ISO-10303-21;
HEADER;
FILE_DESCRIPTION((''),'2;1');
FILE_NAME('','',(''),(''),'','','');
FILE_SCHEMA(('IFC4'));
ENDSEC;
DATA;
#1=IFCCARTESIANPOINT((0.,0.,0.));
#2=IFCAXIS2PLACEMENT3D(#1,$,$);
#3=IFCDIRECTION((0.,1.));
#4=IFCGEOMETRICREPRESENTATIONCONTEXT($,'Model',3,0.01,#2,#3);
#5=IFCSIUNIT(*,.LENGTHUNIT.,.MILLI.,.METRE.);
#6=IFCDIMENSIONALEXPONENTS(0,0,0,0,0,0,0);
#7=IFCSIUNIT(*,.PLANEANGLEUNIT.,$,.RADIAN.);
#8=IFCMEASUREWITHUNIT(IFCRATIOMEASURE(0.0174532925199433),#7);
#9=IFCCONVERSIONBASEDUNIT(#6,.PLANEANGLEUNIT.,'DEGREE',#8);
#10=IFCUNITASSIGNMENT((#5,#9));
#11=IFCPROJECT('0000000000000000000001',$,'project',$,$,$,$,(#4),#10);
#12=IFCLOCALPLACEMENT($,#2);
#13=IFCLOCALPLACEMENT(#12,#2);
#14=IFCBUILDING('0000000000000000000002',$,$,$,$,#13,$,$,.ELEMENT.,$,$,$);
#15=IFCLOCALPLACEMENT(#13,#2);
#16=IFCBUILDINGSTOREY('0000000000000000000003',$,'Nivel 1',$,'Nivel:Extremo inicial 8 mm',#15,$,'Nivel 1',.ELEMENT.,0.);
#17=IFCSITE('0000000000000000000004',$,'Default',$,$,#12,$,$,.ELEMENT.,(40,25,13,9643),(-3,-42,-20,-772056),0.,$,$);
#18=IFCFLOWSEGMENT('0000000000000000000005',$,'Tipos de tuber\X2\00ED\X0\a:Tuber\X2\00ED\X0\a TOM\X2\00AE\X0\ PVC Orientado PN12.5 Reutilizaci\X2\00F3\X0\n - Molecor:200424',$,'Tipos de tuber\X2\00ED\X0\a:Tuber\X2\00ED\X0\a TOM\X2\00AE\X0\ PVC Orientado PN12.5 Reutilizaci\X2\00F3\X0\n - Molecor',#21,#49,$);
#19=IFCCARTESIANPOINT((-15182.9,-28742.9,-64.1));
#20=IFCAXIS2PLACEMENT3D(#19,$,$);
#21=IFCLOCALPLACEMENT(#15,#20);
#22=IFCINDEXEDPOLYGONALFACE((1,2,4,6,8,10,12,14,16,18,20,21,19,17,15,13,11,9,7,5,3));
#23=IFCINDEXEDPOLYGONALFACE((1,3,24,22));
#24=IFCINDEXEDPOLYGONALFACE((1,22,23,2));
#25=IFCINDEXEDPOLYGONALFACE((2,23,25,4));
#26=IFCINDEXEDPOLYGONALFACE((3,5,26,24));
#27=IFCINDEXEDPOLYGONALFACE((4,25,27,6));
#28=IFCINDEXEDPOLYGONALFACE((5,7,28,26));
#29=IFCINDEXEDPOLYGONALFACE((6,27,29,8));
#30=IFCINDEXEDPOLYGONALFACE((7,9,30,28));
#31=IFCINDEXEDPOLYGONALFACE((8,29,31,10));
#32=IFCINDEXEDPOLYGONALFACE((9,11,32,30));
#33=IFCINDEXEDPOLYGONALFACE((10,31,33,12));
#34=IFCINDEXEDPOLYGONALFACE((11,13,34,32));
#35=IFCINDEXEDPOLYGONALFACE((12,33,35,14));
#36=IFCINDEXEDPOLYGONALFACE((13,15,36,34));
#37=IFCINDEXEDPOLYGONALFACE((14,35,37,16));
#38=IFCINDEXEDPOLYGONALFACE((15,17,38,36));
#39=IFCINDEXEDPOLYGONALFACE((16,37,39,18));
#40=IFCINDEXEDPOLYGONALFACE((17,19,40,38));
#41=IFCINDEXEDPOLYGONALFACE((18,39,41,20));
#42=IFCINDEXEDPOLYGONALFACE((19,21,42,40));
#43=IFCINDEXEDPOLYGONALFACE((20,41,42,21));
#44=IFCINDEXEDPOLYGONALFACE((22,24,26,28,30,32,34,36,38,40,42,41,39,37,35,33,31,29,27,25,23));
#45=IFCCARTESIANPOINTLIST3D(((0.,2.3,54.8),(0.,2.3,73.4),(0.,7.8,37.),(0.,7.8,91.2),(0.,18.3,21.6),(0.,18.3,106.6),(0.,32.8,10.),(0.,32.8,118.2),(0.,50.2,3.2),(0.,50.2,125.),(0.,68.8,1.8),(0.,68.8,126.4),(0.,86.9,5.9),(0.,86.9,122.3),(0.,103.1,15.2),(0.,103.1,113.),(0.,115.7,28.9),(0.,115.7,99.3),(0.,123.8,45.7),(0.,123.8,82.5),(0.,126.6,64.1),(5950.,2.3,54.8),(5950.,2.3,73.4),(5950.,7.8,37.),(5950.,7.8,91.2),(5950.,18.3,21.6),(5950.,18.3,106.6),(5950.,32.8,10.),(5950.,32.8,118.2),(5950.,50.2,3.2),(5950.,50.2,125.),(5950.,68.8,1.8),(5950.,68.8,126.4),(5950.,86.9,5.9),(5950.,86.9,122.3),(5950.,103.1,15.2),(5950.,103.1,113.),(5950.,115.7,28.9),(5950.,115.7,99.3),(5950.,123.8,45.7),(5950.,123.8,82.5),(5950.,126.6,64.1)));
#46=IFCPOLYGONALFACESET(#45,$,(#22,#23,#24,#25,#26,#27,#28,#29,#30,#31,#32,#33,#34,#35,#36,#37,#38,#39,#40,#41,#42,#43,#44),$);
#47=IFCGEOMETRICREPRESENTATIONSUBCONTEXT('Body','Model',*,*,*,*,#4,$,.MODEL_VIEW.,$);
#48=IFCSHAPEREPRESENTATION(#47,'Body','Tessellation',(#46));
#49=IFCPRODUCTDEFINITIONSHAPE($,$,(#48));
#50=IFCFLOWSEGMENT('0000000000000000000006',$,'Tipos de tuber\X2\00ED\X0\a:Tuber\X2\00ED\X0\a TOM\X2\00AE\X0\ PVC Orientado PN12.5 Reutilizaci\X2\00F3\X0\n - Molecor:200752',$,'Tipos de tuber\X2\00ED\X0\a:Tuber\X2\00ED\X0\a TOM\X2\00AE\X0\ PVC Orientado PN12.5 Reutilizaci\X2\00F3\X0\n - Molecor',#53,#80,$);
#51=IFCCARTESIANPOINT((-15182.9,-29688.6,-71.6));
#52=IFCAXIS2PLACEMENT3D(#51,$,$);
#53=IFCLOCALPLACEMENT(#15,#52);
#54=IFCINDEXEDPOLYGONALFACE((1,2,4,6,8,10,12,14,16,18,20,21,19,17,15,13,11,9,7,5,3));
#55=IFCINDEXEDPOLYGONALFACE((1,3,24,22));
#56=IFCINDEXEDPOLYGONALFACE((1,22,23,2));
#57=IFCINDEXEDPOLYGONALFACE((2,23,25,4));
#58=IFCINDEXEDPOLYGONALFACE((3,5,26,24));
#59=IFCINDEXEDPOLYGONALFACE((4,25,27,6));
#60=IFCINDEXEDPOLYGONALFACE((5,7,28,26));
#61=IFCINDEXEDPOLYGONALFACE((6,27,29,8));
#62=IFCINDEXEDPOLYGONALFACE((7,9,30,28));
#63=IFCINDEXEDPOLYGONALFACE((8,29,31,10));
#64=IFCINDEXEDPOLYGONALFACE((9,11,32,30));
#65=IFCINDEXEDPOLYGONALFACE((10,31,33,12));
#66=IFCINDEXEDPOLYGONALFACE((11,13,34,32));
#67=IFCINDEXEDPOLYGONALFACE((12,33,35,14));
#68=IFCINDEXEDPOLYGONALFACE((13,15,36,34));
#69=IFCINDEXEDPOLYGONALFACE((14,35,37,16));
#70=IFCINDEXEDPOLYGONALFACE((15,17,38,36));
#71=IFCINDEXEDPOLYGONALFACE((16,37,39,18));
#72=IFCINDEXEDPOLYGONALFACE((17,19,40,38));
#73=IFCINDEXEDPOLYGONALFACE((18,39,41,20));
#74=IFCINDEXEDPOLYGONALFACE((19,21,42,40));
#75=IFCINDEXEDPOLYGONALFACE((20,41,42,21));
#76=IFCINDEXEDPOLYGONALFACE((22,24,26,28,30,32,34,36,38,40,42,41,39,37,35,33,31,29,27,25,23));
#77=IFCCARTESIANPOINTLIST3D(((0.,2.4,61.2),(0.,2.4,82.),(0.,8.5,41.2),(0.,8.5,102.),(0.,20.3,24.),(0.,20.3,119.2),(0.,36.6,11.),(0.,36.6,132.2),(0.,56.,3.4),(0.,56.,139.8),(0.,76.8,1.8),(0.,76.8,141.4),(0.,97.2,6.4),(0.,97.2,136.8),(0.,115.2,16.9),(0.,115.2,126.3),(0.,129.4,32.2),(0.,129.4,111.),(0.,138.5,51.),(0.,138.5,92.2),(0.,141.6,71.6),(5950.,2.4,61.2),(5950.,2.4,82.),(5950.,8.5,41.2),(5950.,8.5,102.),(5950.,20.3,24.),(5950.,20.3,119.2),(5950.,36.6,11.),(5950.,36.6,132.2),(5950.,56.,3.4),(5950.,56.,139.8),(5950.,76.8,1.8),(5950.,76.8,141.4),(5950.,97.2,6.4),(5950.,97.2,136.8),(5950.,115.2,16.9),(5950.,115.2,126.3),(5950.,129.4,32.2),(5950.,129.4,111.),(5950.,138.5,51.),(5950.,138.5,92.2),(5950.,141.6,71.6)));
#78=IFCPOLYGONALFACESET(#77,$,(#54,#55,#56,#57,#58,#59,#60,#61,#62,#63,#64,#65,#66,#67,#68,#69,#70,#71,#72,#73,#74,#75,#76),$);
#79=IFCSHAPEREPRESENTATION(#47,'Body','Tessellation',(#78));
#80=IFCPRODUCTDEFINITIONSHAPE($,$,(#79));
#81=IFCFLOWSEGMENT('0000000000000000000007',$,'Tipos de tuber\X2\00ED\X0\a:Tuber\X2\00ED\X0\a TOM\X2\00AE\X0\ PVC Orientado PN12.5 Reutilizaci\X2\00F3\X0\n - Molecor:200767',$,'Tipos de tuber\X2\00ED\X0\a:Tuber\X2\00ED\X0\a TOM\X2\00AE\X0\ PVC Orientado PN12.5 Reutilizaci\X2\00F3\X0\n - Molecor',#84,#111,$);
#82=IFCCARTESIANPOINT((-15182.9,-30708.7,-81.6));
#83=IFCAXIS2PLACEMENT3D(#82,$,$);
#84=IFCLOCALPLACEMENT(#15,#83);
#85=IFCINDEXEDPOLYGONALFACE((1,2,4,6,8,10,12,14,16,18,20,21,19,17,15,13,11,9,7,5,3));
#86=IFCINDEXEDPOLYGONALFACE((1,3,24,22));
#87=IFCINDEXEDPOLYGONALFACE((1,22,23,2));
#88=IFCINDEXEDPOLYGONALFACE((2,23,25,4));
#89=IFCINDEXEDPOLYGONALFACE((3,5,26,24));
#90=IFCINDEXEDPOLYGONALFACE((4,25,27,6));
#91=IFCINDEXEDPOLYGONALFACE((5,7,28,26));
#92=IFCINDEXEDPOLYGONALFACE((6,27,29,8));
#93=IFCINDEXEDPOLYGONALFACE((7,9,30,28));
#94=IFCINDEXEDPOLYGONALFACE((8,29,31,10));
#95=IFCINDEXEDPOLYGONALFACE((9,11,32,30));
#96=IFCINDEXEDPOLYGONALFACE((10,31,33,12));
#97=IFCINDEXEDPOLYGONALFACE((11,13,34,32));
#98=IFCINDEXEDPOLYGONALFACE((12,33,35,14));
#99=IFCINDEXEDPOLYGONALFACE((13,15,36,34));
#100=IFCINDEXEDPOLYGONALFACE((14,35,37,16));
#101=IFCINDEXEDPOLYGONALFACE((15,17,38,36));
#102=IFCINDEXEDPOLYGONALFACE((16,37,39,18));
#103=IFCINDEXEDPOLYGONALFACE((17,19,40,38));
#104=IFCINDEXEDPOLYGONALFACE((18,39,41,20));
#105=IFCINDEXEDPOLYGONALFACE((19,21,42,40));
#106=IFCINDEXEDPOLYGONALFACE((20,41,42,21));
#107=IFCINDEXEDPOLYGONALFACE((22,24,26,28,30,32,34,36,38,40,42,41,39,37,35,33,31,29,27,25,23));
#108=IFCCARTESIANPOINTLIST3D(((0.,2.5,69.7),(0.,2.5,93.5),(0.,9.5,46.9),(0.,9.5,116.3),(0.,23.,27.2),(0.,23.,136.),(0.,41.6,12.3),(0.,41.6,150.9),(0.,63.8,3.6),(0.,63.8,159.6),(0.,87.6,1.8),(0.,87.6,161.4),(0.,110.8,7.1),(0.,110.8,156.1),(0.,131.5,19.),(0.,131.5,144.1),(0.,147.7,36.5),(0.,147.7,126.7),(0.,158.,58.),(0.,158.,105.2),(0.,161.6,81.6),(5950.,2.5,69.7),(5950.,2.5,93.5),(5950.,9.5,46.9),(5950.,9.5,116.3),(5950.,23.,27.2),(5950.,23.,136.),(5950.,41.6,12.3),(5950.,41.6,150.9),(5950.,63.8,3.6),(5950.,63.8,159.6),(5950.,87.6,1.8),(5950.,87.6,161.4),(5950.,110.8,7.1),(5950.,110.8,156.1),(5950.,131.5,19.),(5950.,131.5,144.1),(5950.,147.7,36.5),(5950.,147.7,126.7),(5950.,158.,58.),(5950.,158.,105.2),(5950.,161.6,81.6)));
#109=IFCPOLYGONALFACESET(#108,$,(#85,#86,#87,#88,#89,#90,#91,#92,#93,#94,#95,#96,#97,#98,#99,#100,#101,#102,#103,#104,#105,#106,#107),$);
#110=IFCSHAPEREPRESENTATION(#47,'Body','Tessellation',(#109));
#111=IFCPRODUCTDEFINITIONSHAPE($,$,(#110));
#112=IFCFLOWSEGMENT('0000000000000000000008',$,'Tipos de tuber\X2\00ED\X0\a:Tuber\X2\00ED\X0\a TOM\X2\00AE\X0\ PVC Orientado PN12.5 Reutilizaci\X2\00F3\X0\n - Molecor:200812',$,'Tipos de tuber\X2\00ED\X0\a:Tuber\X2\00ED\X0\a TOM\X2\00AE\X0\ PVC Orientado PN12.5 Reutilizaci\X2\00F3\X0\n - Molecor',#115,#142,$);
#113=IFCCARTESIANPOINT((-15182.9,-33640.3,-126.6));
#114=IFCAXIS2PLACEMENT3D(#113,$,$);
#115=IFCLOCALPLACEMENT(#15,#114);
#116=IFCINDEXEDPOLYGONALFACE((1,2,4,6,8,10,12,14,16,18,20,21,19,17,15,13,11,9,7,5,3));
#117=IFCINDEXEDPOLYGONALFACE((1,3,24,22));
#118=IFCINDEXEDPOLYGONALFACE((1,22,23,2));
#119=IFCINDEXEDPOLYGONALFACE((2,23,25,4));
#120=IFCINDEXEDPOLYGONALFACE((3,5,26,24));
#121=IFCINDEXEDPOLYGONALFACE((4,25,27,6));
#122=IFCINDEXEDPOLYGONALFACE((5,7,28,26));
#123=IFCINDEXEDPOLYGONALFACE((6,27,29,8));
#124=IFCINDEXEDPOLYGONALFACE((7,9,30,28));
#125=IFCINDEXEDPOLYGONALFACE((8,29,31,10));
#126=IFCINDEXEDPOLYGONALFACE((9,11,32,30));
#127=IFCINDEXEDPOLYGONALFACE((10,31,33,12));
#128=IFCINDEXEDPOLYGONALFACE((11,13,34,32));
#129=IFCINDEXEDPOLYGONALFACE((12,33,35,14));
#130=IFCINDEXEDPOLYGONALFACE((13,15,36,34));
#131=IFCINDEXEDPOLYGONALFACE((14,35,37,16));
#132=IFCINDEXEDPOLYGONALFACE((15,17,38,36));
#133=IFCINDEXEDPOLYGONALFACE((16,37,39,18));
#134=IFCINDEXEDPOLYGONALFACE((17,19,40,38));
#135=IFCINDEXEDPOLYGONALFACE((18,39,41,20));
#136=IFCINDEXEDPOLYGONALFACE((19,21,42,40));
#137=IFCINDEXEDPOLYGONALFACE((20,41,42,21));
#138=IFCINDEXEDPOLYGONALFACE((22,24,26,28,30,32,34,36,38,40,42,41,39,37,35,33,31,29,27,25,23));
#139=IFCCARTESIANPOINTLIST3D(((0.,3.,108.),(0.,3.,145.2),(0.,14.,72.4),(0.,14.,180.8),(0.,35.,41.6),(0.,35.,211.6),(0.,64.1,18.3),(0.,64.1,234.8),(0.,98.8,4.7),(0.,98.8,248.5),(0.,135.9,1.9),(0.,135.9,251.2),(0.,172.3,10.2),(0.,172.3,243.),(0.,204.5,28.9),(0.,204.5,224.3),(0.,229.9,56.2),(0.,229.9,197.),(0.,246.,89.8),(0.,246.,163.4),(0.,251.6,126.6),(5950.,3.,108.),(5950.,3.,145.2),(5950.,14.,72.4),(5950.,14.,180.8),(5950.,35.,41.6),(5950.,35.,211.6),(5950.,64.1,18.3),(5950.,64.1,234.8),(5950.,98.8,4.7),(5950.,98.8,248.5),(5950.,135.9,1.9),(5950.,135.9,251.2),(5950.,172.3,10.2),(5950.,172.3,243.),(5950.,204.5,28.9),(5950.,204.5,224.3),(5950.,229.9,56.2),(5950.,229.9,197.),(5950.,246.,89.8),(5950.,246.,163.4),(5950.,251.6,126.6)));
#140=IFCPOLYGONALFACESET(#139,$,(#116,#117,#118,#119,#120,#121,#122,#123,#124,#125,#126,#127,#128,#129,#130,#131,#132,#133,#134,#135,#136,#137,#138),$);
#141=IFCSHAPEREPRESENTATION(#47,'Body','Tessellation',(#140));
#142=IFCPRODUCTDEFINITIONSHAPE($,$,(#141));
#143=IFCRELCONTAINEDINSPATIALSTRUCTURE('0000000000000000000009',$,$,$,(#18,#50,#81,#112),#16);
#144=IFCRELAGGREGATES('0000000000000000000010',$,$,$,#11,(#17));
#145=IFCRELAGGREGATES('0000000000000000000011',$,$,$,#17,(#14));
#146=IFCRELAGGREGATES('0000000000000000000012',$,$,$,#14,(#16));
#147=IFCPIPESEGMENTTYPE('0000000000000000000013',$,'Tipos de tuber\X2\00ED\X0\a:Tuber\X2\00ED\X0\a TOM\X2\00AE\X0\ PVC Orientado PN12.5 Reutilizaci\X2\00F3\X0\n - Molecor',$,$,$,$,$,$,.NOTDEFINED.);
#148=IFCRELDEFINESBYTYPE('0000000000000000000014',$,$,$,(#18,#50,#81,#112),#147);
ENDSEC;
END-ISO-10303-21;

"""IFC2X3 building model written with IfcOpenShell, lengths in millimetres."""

from ifc_helpers import new_model, entity, si_unit, converted_unit, direction, frame, frame_2d, origin, place, context, subcontext, project, spatial, circle, extrude, type_object, element, save


model = new_model("IFC2X3")

# Units and contexts
model_context = context("Model", 3, precision=0.01, world=origin(), true_north=direction((0.0, 1.0)))
body_context = subcontext(model_context, "Body", "Model", "MODEL_VIEW")
ifc_project = project(units=[si_unit("LENGTHUNIT", "METRE", prefix="MILLI"), converted_unit("PLANEANGLEUNIT", "DEGREE", entity("IfcRatioMeasure", 0.0174532925199433), si_unit("PLANEANGLEUNIT", "RADIAN"), dimensions=[0, 0, 0, 0, 0, 0, 0])], contexts=[model_context])

# Site, building, storey
site_placement = place(None, origin())
site = spatial("IfcSite", under=ifc_project, at=site_placement, Name="Default", CompositionType="ELEMENT", RefLatitude=(40, 25, 13, 9643), RefLongitude=(-3, -42, -20, -772056), RefElevation=0.0)
building_placement = place(site_placement, origin())
building = spatial("IfcBuilding", under=site, at=building_placement, CompositionType="ELEMENT")
storey_placement = place(building_placement, origin())
storey = spatial("IfcBuildingStorey", under=building, at=storey_placement, Name="Nivel 1", ObjectType="Nivel:Extremo inicial 8 mm", LongName="Nivel 1", CompositionType="ELEMENT", Elevation=0.0)

# Flow segments
pipe_segment_type_1 = type_object("IfcPipeSegmentType", Name="Tipos de tubería:Tubería TOM® PVC Orientado PN12.5 Reutilización - Molecor", PredefinedType="NOTDEFINED")
flow_segment_1_placement = place(storey_placement, frame((-15182.9, -28742.9, -64.1)))
element("IfcFlowSegment", 1, at=flow_segment_1_placement, inside=storey, type_object=pipe_segment_type_1, Name="Tipos de tubería:Tubería TOM® PVC Orientado PN12.5 Reutilización - Molecor:200424", ObjectType="Tipos de tubería:Tubería TOM® PVC Orientado PN12.5 Reutilización - Molecor", context=body_context, shape_type="SweptSolid", body=[
    extrude(circle(Radius=62.5, at=frame_2d((0.0, 0.0), x_axis=(1.0, 0.0))), frame((0.0, 64.1, 64.1), z_axis=(1.0, 0.0, 0.0), x_axis=(0.0, 1.0, 0.0)), (0.0, 0.0, 1.0), 5950.0),
])
flow_segment_2_placement = place(storey_placement, frame((-15182.9, -29688.6, -71.6)))
element("IfcFlowSegment", 2, at=flow_segment_2_placement, inside=storey, type_object=pipe_segment_type_1, Name="Tipos de tubería:Tubería TOM® PVC Orientado PN12.5 Reutilización - Molecor:200752", ObjectType="Tipos de tubería:Tubería TOM® PVC Orientado PN12.5 Reutilización - Molecor", context=body_context, shape_type="SweptSolid", body=[
    extrude(circle(Radius=70.0, at=frame_2d((0.0, 0.0), x_axis=(1.0, 0.0))), frame((0.0, 71.6, 71.6), z_axis=(1.0, 0.0, 0.0), x_axis=(0.0, 1.0, 0.0)), (0.0, 0.0, 1.0), 5950.0),
])
flow_segment_3_placement = place(storey_placement, frame((-15182.9, -30708.7, -81.6)))
element("IfcFlowSegment", 3, at=flow_segment_3_placement, inside=storey, type_object=pipe_segment_type_1, Name="Tipos de tubería:Tubería TOM® PVC Orientado PN12.5 Reutilización - Molecor:200767", ObjectType="Tipos de tubería:Tubería TOM® PVC Orientado PN12.5 Reutilización - Molecor", context=body_context, shape_type="SweptSolid", body=[
    extrude(circle(Radius=80.0, at=frame_2d((0.0, 0.0), x_axis=(1.0, 0.0))), frame((0.0, 81.6, 81.6), z_axis=(1.0, 0.0, 0.0), x_axis=(0.0, 1.0, 0.0)), (0.0, 0.0, 1.0), 5950.0),
])
flow_segment_4_placement = place(storey_placement, frame((-15182.9, -33640.3, -126.6)))
element("IfcFlowSegment", 4, at=flow_segment_4_placement, inside=storey, type_object=pipe_segment_type_1, Name="Tipos de tubería:Tubería TOM® PVC Orientado PN12.5 Reutilización - Molecor:200812", ObjectType="Tipos de tubería:Tubería TOM® PVC Orientado PN12.5 Reutilización - Molecor", context=body_context, shape_type="SweptSolid", body=[
    extrude(circle(Radius=125.0, at=frame_2d((0.0, 0.0), x_axis=(1.0, 0.0))), frame((0.0, 126.6, 126.6), z_axis=(1.0, 0.0, 0.0), x_axis=(0.0, 1.0, 0.0)), (0.0, 0.0, 1.0), 5950.0),
])

save(model, "model.ifc")
